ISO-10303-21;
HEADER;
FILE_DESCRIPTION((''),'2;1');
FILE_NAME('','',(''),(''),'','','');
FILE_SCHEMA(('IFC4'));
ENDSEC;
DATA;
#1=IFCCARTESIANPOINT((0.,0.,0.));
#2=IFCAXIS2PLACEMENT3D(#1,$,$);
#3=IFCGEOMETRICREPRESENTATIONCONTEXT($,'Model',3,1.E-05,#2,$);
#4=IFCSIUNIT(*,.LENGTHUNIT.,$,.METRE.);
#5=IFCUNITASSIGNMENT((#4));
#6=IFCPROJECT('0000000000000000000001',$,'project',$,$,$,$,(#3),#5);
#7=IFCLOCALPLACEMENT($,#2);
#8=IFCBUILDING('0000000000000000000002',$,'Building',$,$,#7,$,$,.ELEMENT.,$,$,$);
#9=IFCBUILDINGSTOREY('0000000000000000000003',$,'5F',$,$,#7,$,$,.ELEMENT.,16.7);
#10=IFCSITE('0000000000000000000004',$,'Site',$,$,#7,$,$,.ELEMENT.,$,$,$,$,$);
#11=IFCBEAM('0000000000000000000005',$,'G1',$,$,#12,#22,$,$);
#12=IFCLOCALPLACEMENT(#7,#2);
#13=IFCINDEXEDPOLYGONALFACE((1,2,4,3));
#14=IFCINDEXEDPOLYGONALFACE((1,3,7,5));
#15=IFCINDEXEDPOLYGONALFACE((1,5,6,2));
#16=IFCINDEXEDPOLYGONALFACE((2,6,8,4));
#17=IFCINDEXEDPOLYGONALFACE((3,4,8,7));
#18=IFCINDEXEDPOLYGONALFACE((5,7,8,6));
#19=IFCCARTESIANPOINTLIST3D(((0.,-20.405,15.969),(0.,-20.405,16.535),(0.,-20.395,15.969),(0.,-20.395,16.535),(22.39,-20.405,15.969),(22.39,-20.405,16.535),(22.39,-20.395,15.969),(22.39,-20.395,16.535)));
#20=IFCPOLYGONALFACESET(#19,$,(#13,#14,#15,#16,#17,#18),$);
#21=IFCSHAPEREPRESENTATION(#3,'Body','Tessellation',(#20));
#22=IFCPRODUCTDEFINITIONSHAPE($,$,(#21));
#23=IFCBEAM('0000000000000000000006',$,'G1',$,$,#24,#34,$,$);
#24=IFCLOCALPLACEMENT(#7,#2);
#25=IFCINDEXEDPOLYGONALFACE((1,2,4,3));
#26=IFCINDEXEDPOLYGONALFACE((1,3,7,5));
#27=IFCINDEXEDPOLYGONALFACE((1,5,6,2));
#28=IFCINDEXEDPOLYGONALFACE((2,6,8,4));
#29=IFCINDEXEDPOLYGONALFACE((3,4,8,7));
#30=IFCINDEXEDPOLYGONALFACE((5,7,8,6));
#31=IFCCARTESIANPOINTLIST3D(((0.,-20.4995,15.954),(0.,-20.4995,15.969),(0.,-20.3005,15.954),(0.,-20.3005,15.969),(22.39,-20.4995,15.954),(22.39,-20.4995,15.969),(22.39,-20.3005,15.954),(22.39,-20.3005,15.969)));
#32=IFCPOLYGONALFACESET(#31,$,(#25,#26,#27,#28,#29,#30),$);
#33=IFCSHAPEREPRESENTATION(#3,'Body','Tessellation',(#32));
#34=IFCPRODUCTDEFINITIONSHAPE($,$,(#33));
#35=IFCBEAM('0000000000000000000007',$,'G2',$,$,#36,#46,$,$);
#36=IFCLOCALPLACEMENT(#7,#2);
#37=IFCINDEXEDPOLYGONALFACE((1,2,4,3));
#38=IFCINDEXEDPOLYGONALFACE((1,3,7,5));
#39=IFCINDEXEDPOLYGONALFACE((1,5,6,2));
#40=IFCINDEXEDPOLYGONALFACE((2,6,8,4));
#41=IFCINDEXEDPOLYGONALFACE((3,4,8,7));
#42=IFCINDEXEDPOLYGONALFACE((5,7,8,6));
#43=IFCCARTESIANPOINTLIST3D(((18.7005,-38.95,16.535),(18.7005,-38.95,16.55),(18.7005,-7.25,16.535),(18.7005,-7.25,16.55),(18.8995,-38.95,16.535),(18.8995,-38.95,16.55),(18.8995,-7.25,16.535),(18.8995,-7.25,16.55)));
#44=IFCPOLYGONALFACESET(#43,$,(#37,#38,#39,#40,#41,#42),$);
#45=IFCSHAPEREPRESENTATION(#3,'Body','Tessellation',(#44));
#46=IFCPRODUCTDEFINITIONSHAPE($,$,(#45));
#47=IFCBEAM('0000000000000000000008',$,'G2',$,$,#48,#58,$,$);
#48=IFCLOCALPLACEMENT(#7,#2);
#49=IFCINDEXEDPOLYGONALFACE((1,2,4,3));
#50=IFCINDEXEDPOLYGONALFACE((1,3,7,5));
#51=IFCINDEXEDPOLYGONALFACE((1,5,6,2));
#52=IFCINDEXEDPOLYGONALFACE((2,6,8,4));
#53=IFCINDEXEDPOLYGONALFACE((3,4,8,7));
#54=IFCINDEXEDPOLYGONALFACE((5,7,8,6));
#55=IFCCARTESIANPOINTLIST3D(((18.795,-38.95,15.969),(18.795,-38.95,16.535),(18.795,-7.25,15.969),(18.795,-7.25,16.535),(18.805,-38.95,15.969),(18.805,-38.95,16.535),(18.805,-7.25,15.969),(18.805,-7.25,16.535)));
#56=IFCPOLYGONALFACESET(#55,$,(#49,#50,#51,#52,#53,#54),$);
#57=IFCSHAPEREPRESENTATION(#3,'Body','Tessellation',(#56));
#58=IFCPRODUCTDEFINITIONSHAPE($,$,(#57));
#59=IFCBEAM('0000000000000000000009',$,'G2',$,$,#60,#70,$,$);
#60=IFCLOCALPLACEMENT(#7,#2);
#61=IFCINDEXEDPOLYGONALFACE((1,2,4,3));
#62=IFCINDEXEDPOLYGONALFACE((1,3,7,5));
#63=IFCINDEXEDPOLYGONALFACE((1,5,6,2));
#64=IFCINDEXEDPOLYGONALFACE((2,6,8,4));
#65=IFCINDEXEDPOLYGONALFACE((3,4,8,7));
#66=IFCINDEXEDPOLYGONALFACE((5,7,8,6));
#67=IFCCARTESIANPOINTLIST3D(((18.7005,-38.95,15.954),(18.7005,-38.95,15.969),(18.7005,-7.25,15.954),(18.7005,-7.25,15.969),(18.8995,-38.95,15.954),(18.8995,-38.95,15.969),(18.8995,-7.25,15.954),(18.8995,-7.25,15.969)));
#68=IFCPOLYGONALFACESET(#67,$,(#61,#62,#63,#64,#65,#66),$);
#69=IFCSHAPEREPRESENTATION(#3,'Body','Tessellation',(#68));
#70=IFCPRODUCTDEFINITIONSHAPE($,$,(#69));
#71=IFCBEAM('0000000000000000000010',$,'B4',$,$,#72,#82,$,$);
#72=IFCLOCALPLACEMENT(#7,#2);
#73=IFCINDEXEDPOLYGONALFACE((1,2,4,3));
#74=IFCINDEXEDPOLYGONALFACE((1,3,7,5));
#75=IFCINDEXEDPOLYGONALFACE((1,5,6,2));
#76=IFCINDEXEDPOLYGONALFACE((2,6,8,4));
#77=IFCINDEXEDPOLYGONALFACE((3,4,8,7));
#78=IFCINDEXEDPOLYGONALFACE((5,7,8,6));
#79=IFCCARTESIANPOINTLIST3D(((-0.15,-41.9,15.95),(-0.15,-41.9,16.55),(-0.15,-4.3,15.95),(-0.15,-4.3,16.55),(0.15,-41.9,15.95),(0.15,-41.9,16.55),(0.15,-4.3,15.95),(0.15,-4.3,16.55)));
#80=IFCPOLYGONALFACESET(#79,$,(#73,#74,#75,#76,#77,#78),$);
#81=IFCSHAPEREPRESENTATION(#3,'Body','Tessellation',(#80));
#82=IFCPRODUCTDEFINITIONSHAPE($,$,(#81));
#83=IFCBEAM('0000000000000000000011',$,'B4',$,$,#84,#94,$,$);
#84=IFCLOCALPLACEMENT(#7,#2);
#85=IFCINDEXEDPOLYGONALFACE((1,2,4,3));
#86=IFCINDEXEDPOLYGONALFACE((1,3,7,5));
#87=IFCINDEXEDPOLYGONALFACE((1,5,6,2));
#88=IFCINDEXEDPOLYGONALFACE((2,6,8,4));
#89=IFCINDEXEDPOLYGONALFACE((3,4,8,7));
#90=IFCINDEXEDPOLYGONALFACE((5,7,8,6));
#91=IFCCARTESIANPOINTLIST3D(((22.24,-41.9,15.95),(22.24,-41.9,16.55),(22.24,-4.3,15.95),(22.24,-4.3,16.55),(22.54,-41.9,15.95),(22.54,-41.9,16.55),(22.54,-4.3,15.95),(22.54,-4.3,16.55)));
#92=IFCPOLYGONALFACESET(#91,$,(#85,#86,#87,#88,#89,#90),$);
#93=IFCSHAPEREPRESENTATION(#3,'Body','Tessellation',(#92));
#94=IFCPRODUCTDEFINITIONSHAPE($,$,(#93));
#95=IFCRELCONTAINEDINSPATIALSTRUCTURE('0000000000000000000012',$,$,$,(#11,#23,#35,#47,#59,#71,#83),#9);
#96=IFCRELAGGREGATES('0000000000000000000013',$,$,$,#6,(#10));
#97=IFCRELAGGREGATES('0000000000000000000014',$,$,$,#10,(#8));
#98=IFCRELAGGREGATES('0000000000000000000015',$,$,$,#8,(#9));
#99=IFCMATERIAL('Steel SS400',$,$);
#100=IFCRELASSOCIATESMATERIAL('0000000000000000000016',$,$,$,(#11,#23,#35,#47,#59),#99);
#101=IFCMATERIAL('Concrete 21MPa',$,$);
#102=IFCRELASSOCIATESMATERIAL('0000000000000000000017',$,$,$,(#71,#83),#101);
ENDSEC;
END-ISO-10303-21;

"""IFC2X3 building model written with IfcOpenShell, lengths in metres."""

from ifc_helpers import new_model, si_unit, frame, origin, origin_2d, place, context, project, spatial, rectangle, extrude, material, element, save


model = new_model("IFC2X3")

# Units and contexts
model_context = context("Model", 3, precision=1e-05, world=origin())
ifc_project = project(units=[si_unit("LENGTHUNIT", "METRE")], contexts=[model_context])

# Site, building, storey
placement = place(None, origin())
site = spatial("IfcSite", under=ifc_project, at=placement, Name="Site", CompositionType="ELEMENT")
building = spatial("IfcBuilding", under=site, at=placement, Name="Building", CompositionType="ELEMENT")
storey = spatial("IfcBuildingStorey", under=building, at=placement, Name="5F", CompositionType="ELEMENT", Elevation=16.7)

# Shared definitions
ifc_material_1 = material(Name="Concrete 21MPa")
ifc_material_2 = material(Name="Steel SS400")

# Beams
beam_1_placement = place(None, frame((11.195, -20.4, 15.969)))
element("IfcBeam", 1, at=beam_1_placement, inside=storey, material=ifc_material_2, Name="G1", context=model_context, shape_type="SweptSolid", body=[
    extrude(rectangle(XDim=22.39, YDim=0.01, at=origin_2d()), origin(), (0.0, 0.0, 1.0), 0.566),
])
beam_2_placement = place(None, frame((11.195, -20.4, 15.954)))
element("IfcBeam", 2, at=beam_2_placement, inside=storey, material=ifc_material_2, Name="G1", context=model_context, shape_type="SweptSolid", body=[
    extrude(rectangle(XDim=22.39, YDim=0.199, at=origin_2d()), origin(), (0.0, 0.0, 1.0), 0.015),
])
beam_3_placement = place(None, frame((18.8, -23.1, 16.535)))
element("IfcBeam", 3, at=beam_3_placement, inside=storey, material=ifc_material_2, Name="G2", context=model_context, shape_type="SweptSolid", body=[
    extrude(rectangle(XDim=0.199, YDim=31.7, at=origin_2d()), origin(), (0.0, 0.0, 1.0), 0.015),
])
beam_4_placement = place(None, frame((18.8, -23.1, 15.969)))
element("IfcBeam", 4, at=beam_4_placement, inside=storey, material=ifc_material_2, Name="G2", context=model_context, shape_type="SweptSolid", body=[
    extrude(rectangle(XDim=0.01, YDim=31.7, at=origin_2d()), origin(), (0.0, 0.0, 1.0), 0.566),
])
beam_5_placement = place(None, frame((18.8, -23.1, 15.954)))
element("IfcBeam", 5, at=beam_5_placement, inside=storey, material=ifc_material_2, Name="G2", context=model_context, shape_type="SweptSolid", body=[
    extrude(rectangle(XDim=0.199, YDim=31.7, at=origin_2d()), origin(), (0.0, 0.0, 1.0), 0.015),
])
for number, where, name in (
    (6, (0.0, -23.1, 15.95), "B4"),
    (7, (22.39, -23.1, 15.95), "B4"),
):
    element("IfcBeam", number, at=place(None, frame(where)), inside=storey, material=ifc_material_1, Name=name, context=model_context, shape_type="SweptSolid", body=[
        extrude(rectangle(XDim=0.3, YDim=37.6, at=origin_2d()), origin(), (0.0, 0.0, 1.0), 0.6),
    ])

save(model, "model.ifc")
